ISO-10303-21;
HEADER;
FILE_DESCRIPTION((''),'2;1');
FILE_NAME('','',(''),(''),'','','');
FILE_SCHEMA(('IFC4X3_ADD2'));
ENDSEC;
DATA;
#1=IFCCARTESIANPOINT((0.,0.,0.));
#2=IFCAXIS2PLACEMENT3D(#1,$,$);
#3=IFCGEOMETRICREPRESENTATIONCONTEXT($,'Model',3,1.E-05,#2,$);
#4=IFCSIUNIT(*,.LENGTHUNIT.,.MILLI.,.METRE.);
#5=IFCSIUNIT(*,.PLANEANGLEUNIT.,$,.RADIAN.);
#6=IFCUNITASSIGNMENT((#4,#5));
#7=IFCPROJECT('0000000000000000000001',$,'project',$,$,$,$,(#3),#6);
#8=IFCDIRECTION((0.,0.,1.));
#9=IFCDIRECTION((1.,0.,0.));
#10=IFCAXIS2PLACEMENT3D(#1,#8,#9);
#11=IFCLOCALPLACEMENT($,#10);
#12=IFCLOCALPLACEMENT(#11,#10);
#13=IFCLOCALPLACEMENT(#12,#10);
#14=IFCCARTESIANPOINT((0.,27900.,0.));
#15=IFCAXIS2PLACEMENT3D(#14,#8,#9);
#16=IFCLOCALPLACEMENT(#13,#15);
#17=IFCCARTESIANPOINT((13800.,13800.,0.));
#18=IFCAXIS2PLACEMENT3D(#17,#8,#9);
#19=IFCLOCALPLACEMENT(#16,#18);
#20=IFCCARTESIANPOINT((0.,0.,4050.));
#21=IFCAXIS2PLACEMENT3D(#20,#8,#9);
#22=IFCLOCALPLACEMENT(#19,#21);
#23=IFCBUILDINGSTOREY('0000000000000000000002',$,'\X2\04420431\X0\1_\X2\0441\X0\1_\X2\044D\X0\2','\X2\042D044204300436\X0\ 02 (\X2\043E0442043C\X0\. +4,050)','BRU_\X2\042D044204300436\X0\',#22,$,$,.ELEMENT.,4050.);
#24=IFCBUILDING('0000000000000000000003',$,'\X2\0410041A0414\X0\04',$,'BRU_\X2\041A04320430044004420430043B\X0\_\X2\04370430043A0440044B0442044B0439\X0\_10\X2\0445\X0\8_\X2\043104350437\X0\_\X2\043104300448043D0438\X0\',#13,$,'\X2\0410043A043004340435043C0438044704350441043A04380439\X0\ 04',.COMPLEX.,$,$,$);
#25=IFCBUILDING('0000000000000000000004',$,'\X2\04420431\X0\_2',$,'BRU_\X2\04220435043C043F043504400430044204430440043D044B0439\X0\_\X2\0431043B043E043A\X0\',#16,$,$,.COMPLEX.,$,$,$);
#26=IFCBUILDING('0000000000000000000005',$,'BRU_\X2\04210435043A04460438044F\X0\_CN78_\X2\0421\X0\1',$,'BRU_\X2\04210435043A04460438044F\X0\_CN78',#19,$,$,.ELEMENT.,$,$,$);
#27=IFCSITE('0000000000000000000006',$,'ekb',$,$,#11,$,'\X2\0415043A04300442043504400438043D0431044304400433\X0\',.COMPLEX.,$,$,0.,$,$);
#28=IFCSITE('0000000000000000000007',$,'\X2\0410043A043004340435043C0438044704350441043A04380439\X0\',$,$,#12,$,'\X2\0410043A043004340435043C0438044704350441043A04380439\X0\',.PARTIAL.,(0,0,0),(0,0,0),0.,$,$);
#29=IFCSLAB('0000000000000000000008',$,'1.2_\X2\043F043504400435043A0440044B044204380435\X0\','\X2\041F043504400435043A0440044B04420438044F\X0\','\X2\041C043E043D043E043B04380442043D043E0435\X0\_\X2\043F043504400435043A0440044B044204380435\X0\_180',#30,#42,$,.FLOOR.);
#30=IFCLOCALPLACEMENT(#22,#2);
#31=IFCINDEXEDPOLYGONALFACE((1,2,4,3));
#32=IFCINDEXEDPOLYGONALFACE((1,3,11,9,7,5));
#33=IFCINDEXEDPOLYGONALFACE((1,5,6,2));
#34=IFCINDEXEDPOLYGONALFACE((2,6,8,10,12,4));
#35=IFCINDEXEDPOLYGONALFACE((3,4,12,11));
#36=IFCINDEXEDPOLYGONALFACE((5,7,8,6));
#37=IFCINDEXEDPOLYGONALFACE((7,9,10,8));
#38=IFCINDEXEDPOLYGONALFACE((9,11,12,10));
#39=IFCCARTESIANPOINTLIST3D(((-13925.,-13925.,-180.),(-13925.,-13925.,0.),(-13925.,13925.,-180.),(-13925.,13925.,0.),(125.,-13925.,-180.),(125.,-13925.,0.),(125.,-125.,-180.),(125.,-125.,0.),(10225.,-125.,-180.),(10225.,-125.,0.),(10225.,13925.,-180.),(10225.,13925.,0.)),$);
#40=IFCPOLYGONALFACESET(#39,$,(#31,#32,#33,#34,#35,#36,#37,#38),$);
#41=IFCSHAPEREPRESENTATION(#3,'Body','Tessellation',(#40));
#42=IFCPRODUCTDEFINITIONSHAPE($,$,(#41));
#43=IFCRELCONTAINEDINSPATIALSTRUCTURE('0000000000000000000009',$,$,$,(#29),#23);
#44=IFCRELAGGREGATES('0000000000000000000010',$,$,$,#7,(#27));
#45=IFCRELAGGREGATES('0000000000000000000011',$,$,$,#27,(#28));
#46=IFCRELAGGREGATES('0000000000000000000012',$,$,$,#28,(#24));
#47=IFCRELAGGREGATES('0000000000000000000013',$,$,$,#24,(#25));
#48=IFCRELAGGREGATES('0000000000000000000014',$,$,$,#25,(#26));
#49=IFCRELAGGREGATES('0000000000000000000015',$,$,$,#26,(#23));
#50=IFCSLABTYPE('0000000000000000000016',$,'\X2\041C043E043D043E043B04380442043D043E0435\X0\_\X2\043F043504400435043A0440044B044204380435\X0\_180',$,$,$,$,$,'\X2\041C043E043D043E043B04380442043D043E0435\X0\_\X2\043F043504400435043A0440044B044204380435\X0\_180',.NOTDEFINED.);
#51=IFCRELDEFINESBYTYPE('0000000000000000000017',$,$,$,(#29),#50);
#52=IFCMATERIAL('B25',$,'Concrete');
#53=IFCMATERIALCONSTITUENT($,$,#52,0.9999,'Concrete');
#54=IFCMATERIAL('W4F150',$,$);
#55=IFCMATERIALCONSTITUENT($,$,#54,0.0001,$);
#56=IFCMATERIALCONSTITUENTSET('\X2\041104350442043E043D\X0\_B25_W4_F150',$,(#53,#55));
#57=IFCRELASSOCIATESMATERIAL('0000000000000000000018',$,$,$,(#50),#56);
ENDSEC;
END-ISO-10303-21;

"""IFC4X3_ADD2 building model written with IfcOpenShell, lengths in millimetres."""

from ifc_helpers import new_model, si_unit, frame, origin, origin_with_axes, place, context, project, spatial, polyline, outline, extrude, material, constituent, constituent_set, type_object, element, save


model = new_model("IFC4X3_ADD2")

# Units and contexts
model_context = context("Model", 3, precision=1e-05, world=origin())
ifc_project = project(units=[si_unit("LENGTHUNIT", "METRE", prefix="MILLI"), si_unit("PLANEANGLEUNIT", "RADIAN")], contexts=[model_context])

# Sites, buildings, storey
site_1_placement = place(None, origin_with_axes())
site_1 = spatial("IfcSite", under=ifc_project, at=site_1_placement, Name="ekb", LongName="Екатеринбург", CompositionType="COMPLEX", RefElevation=0.0)
site_2_placement = place(site_1_placement, origin_with_axes())
site_2 = spatial("IfcSite", under=site_1, at=site_2_placement, Name="Академический", LongName="Академический", CompositionType="PARTIAL", RefLatitude=(0, 0, 0), RefLongitude=(0, 0, 0), RefElevation=0.0)
building_1_placement = place(site_2_placement, origin_with_axes())
building_1 = spatial("IfcBuilding", under=site_2, at=building_1_placement, Name="АКД04", ObjectType="BRU_Квартал_закрытый_10х8_без_башни", LongName="Академический 04", CompositionType="COMPLEX")
building_2_placement = place(building_1_placement, frame((0.0, 27900.0, 0.0), z_axis=(0.0, 0.0, 1.0), x_axis=(1.0, 0.0, 0.0)))
building_2 = spatial("IfcBuilding", under=building_1, at=building_2_placement, Name="тб_2", ObjectType="BRU_Температурный_блок", CompositionType="COMPLEX")
building_3_placement = place(building_2_placement, frame((13800.0, 13800.0, 0.0), z_axis=(0.0, 0.0, 1.0), x_axis=(1.0, 0.0, 0.0)))
building_3 = spatial("IfcBuilding", under=building_2, at=building_3_placement, Name="BRU_Секция_CN78_С1", ObjectType="BRU_Секция_CN78", CompositionType="ELEMENT")
storey_placement = place(building_3_placement, frame((0.0, 0.0, 4050.0), z_axis=(0.0, 0.0, 1.0), x_axis=(1.0, 0.0, 0.0)))
storey = spatial("IfcBuildingStorey", under=building_3, at=storey_placement, Name="тб1_с1_э2", Description="Этаж 02 (отм. +4,050)", ObjectType="BRU_Этаж", CompositionType="ELEMENT", Elevation=4050.0)

# Shared definitions
ifc_material_1 = material(Name="B25", Category="Concrete")
ifc_material_2 = material(Name="W4F150")

# Slab
ifc_constituent_1 = constituent(ifc_material_1, Category="Concrete", fraction=0.9999)
ifc_constituent_2 = constituent(ifc_material_2, fraction=0.0001)
ifc_constituent_set_1 = constituent_set(constituents=[ifc_constituent_1, ifc_constituent_2], Name="Бетон_B25_W4_F150")
slab_type = type_object("IfcSlabType", Name="Монолитное_перекрытие_180", ElementType="Монолитное_перекрытие_180", PredefinedType="NOTDEFINED", material=ifc_constituent_set_1)
slab_placement = place(storey_placement, frame((0.0, 0.0, -180.0), z_axis=(0.0, 0.0, 1.0), x_axis=(1.0, 0.0, 0.0)))
element("IfcSlab", 1, at=slab_placement, inside=storey, type_object=slab_type, Name="1.2_перекрытие", Description="Перекрытия", ObjectType="Монолитное_перекрытие_180", PredefinedType="FLOOR", context=model_context, shape_type="SweptSolid", body=[
    extrude(outline(polyline([(-13925.0, -13925.0), (125.0, -13925.0), (125.0, -125.0), (10225.0, -125.0), (10225.0, 13925.0), (-13925.0, 13925.0), (-13925.0, -13925.0)])), origin_with_axes(), (0.0, 0.0, 1.0), 180.0),
])

save(model, "model.ifc")
